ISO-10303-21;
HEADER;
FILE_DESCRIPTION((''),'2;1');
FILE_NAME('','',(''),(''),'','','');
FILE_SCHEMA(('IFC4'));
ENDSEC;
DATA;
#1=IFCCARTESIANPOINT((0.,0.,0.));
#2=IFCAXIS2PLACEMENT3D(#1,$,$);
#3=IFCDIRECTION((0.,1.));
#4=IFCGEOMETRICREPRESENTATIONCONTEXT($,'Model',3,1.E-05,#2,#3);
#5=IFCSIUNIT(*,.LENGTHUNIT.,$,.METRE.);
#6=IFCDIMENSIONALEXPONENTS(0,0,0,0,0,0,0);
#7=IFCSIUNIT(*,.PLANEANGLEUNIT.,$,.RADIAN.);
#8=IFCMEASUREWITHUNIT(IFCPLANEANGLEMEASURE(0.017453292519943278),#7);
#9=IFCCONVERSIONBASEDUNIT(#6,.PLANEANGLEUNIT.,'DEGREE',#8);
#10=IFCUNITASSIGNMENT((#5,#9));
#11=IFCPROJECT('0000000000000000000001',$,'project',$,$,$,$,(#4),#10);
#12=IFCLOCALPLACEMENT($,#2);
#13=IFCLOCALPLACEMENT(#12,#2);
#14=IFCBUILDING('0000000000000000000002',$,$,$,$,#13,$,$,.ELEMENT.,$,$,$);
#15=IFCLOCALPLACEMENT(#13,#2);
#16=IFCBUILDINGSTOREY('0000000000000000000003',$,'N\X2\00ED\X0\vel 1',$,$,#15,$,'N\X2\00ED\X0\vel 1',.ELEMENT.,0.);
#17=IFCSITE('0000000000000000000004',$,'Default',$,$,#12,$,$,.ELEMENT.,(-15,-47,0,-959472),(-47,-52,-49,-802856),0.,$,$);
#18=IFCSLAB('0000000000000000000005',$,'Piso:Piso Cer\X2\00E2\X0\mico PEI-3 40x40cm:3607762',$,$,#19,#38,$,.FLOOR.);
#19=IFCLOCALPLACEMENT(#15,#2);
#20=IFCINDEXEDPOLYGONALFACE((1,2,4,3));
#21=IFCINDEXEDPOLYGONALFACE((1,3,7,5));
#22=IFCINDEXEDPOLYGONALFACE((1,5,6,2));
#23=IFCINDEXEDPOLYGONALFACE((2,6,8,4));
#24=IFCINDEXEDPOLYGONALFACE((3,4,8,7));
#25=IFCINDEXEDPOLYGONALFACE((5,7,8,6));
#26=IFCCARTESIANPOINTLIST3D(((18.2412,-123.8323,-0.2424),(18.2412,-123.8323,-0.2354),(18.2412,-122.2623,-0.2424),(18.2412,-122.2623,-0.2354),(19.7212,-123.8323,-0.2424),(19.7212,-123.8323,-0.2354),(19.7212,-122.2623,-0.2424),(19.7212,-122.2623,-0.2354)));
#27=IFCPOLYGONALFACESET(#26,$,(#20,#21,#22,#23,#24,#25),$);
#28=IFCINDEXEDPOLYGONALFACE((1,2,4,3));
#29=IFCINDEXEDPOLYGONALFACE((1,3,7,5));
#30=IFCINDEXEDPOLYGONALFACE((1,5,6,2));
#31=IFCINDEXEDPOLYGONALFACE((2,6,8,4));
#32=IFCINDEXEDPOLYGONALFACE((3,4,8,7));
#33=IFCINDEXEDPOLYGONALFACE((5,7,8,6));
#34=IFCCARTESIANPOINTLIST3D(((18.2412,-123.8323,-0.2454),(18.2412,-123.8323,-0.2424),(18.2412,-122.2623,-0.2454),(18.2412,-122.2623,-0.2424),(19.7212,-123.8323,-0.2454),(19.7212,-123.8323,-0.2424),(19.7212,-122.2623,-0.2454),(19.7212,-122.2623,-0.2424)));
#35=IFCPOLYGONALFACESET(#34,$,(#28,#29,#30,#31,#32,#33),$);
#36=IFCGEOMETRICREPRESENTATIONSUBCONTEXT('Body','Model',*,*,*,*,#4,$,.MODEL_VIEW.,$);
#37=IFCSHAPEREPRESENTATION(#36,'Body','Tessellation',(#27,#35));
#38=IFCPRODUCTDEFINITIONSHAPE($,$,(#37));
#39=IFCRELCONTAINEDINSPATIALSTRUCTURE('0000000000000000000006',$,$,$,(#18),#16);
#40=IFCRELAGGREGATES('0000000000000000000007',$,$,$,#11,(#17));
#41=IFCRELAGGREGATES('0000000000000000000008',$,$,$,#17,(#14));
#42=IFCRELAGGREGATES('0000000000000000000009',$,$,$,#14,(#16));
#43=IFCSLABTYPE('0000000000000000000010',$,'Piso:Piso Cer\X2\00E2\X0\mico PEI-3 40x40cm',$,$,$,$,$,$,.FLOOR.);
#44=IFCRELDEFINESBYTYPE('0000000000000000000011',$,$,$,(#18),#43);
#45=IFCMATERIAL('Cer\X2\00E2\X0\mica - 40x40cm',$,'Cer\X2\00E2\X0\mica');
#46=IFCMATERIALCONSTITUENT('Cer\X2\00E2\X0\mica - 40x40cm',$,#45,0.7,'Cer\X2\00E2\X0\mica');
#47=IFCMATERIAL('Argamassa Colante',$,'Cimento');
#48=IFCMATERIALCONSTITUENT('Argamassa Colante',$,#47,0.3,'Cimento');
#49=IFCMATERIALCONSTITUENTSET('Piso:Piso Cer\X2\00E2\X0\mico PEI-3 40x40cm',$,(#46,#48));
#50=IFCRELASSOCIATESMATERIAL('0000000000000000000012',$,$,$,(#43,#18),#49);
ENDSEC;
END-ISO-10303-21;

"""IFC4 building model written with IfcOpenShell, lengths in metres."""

from ifc_helpers import new_model, entity, si_unit, converted_unit, direction, frame, origin, place, context, subcontext, project, spatial, indexed_curve, outline, extrude, material, constituent, constituent_set, type_object, element, save


model = new_model("IFC4")

# Units and contexts
model_context = context("Model", 3, precision=1e-05, world=origin(), true_north=direction((0.0, 1.0)))
body_context = subcontext(model_context, "Body", "Model", "MODEL_VIEW")
ifc_project = project(units=[si_unit("LENGTHUNIT", "METRE"), converted_unit("PLANEANGLEUNIT", "DEGREE", entity("IfcPlaneAngleMeasure", 0.017453292519943278), si_unit("PLANEANGLEUNIT", "RADIAN"), dimensions=[0, 0, 0, 0, 0, 0, 0])], contexts=[model_context])

# Site, building, storey
site_placement = place(None, origin())
site = spatial("IfcSite", under=ifc_project, at=site_placement, Name="Default", CompositionType="ELEMENT", RefLatitude=(-15, -47, 0, -959472), RefLongitude=(-47, -52, -49, -802856), RefElevation=0.0)
building_placement = place(site_placement, origin())
building = spatial("IfcBuilding", under=site, at=building_placement, CompositionType="ELEMENT")
storey_placement = place(building_placement, origin())
storey = spatial("IfcBuildingStorey", under=building, at=storey_placement, Name="Nível 1", LongName="Nível 1", CompositionType="ELEMENT", Elevation=0.0)

# Slab
ifc_material_1 = material(Name="Cerâmica - 40x40cm", Category="Cerâmica")
ifc_constituent_1 = constituent(ifc_material_1, Name="Cerâmica - 40x40cm", Category="Cerâmica", fraction=0.7)
ifc_material_2 = material(Name="Argamassa Colante", Category="Cimento")
ifc_constituent_2 = constituent(ifc_material_2, Name="Argamassa Colante", Category="Cimento", fraction=0.3)
ifc_constituent_set = constituent_set(constituents=[ifc_constituent_1, ifc_constituent_2], Name="Piso:Piso Cerâmico PEI-3 40x40cm")
slab_type_1 = type_object("IfcSlabType", Name="Piso:Piso Cerâmico PEI-3 40x40cm", PredefinedType="FLOOR", material=ifc_constituent_set)
slab_1_placement = place(storey_placement, origin())
element("IfcSlab", 1, at=slab_1_placement, inside=storey, type_object=slab_type_1, material=ifc_constituent_set, Name="Piso:Piso Cerâmico PEI-3 40x40cm:3607762", PredefinedType="FLOOR", context=body_context, shape_type="SweptSolid", body=[
    extrude(outline(indexed_curve([(-0.74, -0.785), (0.74, -0.785), (0.74, 0.785), (-0.74, 0.785), (-0.74, -0.785)], self_intersect=False)), frame((18.9812, -123.0473, -0.2424), z_axis=(0.0, 0.0, 1.0), x_axis=(-1.0, 0.0, 0.0)), (0.0, 0.0, 1.0), 0.007),
    extrude(outline(indexed_curve([(-0.74, -0.785), (0.74, -0.785), (0.74, 0.785), (-0.74, 0.785), (-0.74, -0.785)], self_intersect=False)), frame((18.9812, -123.0473, -0.2454), z_axis=(0.0, 0.0, 1.0), x_axis=(-1.0, 0.0, 0.0)), (0.0, 0.0, 1.0), 0.003),
])

save(model, "model.ifc")
